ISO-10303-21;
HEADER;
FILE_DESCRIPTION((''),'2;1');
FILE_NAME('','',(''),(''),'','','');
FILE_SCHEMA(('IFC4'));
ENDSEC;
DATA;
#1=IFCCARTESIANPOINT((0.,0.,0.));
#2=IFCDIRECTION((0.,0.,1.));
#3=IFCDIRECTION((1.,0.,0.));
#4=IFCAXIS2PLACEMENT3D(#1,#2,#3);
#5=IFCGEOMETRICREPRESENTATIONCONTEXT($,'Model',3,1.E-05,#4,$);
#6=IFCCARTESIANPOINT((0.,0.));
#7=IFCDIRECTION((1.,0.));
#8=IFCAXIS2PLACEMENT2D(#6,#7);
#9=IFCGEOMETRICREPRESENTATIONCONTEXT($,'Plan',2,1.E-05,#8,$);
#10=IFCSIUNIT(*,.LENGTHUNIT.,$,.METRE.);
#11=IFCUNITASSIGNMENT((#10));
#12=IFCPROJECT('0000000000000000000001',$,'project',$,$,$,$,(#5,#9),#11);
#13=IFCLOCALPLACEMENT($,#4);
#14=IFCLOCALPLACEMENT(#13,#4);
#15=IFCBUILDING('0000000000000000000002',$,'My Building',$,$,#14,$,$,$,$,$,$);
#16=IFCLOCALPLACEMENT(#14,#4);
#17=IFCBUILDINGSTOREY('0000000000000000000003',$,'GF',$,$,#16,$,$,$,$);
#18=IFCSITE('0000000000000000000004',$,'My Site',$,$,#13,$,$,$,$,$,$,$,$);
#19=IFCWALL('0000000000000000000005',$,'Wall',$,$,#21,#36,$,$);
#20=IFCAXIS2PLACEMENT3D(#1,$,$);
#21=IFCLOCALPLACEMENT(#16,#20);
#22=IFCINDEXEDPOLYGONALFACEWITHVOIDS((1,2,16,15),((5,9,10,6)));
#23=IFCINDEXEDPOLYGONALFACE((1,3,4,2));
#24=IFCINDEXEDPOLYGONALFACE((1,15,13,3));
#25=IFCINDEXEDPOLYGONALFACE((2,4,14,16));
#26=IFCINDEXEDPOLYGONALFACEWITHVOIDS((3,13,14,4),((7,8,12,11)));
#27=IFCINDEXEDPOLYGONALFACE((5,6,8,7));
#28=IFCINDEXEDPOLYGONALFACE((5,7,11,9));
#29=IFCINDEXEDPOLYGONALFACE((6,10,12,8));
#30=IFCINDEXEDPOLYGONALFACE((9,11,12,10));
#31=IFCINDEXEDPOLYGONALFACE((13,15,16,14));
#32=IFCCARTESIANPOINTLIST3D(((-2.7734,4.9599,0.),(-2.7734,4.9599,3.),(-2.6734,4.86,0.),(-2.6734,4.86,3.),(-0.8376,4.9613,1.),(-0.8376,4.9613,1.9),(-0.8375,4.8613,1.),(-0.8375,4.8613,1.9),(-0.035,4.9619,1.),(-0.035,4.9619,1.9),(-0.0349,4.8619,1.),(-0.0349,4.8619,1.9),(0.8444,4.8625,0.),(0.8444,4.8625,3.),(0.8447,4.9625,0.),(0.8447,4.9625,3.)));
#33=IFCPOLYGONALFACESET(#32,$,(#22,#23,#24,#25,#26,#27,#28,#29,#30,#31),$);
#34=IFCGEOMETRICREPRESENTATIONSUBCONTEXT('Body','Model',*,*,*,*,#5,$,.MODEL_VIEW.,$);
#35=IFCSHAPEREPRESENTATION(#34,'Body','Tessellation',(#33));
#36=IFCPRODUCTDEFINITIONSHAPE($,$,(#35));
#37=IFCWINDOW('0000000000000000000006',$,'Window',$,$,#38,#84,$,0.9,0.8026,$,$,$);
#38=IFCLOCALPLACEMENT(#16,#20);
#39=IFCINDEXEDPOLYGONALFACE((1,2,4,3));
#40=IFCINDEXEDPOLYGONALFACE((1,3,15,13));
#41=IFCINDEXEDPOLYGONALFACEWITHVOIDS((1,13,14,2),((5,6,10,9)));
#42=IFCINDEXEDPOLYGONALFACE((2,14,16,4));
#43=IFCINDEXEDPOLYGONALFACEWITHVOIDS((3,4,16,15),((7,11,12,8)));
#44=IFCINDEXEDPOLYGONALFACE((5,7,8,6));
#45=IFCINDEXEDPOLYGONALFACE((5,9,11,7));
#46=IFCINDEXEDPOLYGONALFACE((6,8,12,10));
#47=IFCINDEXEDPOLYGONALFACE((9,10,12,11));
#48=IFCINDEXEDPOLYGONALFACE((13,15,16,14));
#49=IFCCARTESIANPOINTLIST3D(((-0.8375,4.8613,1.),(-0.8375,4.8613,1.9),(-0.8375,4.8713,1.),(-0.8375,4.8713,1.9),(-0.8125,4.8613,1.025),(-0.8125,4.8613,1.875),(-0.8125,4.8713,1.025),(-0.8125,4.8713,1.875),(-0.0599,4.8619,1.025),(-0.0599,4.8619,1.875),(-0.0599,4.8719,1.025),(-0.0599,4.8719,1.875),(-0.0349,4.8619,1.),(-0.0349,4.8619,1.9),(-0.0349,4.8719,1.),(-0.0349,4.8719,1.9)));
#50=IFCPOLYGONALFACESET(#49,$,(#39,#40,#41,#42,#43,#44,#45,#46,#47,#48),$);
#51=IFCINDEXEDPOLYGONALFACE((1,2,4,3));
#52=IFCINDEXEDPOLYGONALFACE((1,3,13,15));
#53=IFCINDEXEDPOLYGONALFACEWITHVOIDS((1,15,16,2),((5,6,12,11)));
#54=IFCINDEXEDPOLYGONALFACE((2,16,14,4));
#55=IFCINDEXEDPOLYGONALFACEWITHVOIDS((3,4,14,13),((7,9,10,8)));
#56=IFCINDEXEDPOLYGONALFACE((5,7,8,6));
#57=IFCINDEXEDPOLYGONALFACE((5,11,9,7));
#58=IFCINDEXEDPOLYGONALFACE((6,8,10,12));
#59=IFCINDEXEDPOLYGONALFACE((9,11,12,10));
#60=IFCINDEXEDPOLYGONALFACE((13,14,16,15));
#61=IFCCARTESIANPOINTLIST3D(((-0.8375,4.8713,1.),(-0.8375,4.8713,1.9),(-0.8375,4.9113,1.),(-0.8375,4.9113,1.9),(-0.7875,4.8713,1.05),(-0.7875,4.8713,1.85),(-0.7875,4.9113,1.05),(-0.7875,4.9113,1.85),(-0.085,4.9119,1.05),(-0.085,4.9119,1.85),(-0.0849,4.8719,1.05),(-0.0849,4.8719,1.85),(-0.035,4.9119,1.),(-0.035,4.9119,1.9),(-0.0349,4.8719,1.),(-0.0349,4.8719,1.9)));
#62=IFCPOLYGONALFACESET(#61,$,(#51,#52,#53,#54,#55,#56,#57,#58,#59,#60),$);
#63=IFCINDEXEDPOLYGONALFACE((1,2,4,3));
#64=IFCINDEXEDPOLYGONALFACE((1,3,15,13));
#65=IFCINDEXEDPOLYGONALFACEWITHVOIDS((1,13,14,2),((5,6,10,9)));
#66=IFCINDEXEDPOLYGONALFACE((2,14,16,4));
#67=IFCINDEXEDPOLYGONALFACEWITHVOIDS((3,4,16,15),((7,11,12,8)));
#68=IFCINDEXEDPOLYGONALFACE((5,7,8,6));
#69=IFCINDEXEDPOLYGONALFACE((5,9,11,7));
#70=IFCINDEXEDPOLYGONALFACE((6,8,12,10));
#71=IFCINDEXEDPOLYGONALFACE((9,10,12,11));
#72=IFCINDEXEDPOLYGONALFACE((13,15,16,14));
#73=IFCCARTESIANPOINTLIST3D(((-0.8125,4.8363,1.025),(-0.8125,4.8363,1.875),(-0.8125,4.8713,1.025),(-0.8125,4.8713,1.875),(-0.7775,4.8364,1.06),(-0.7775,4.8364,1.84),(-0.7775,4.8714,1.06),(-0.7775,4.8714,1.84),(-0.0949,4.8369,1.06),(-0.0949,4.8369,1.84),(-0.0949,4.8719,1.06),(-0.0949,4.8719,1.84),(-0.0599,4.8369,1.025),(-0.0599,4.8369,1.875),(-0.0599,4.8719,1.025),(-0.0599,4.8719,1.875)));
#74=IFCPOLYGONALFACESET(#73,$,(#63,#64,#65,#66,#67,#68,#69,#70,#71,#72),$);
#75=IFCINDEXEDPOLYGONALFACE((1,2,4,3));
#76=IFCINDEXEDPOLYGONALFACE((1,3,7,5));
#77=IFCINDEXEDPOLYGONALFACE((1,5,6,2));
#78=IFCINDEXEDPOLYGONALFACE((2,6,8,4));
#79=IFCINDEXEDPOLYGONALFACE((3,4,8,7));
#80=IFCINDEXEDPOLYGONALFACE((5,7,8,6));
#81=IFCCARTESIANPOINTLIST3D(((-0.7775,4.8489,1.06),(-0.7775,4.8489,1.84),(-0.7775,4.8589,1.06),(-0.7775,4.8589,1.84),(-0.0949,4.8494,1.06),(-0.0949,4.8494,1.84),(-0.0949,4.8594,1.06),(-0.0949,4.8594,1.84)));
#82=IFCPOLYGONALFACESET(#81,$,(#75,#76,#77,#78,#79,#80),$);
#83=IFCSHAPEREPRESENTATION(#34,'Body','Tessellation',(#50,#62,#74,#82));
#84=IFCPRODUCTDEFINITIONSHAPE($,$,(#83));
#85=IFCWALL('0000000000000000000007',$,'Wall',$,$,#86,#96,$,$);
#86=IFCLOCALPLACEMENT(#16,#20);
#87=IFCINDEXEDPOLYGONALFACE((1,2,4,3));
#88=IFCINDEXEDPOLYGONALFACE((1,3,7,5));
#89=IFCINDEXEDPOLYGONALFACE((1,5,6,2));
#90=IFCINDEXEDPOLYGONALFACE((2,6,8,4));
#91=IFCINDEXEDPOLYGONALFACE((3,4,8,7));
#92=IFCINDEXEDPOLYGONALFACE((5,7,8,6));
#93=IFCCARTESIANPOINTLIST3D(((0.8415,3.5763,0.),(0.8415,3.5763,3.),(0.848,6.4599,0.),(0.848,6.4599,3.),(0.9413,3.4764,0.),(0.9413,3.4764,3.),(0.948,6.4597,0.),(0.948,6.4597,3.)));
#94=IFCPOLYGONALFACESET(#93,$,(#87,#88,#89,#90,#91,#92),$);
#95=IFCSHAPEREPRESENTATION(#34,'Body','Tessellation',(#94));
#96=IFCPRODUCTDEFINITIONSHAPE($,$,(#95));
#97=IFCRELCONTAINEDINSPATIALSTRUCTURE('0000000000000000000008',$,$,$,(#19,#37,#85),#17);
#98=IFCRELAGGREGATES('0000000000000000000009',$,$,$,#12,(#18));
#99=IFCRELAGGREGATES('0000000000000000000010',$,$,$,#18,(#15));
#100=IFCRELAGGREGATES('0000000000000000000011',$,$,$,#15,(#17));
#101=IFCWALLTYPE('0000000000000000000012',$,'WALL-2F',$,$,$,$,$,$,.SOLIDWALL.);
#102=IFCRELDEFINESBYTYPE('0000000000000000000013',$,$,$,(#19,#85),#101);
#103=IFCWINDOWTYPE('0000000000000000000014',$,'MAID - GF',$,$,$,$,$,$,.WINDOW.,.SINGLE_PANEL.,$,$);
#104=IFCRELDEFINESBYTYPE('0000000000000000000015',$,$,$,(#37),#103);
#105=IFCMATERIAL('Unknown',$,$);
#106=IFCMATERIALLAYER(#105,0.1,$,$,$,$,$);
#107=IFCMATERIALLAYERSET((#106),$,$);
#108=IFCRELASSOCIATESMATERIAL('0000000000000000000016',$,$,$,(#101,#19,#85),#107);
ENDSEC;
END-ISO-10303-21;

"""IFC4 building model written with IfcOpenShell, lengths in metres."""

from ifc_helpers import new_model, entity, si_unit, frame, origin_with_axes, origin_2d_with_axis, place, context, subcontext, project, spatial, line, indexed_curve, outline, extrude, shape, source, transform, mapped, material, layer, layer_set, layer_usage, type_object, type_shapes, element, fill, save


model = new_model("IFC4")

# Units and contexts
model_context = context("Model", 3, precision=1e-05, world=origin_with_axes())
plan_context = context("Plan", 2, precision=1e-05, world=origin_2d_with_axis())
body_context_1 = subcontext(model_context, "Body", "Model", "MODEL_VIEW")
body_context_2 = subcontext(plan_context, "Body", "Plan", "PLAN_VIEW")
ifc_project = project(units=[si_unit("LENGTHUNIT", "METRE")], contexts=[model_context, plan_context])

# Site, building, storey
site_placement = place(None, origin_with_axes())
site = spatial("IfcSite", under=ifc_project, at=site_placement, Name="My Site")
building_placement = place(site_placement, origin_with_axes())
building = spatial("IfcBuilding", under=site, at=building_placement, Name="My Building")
storey_placement = place(building_placement, origin_with_axes())
storey = spatial("IfcBuildingStorey", under=building, at=storey_placement, Name="GF")

# Shared definitions
ifc_material_1 = material(Name="Unknown")

# Shared definitions
ifc_layer_1 = layer(ifc_material_1, 0.1)
ifc_layer_set_1 = layer_set([ifc_layer_1])
wall_type_1 = type_object("IfcWallType", Name="WALL-2F", PredefinedType="SOLIDWALL", material=ifc_layer_set_1)

# Wall, opening, window
ifc_layer_usage_1 = layer_usage(ifc_layer_set_1, "AXIS2", "POSITIVE", 0.0)
wall_1_placement = place(storey_placement, frame((-2.7734, 4.8599, 0.0), z_axis=(0.0, 0.0, 1.0), x_axis=(1.0, 0.000731, 0.0)))
wall_1 = element("IfcWall", 1, at=wall_1_placement, inside=storey, type_object=wall_type_1, material=ifc_layer_usage_1, Name="Wall", context=body_context_1, shape_type="SweptSolid", body=[
    extrude(outline(indexed_curve([(0.1, 0.0), (0.0001, 0.1), (3.6181, 0.1), (3.6178, 0.0)], segments=[line(1, 2, 3, 4, 1)])), origin_with_axes(), (0.0, 0.0, 1.0), 3.0),
])
shared_shape_1 = source(origin_with_axes(), body_context_1, "Body", "SweptSolid", [
    extrude(outline(indexed_curve([(0.0, 0.0), (0.8026, 0.0), (0.8026, 0.9), (0.0, 0.9)], segments=[line(1, 2, 3, 4, 1)])), frame((0.0, -0.6, 0.0), z_axis=(0.0, -1.0, 0.0), x_axis=(1.0, 0.0, 0.0)), (0.0, 0.0, -1.0), 1.2),
])
opening_1_placement = place(wall_1_placement, frame((2.7385, 0.1, 1.0), z_axis=(0.0, 0.0, 1.0), x_axis=(-1.0, 0.0, 0.0)))
opening_1 = element("IfcOpeningElement", 2, at=opening_1_placement, cuts=wall_1, PredefinedType="OPENING", context=body_context_1, shape_type="MappedRepresentation", body=[
    mapped(shared_shape_1, transform((0.0, 0.0, 0.0), x_axis=(1.0, 0.0, 0.0), y_axis=(0.0, 1.0, 0.0), z_axis=(0.0, 0.0, 1.0), scale=1.0)),
])
window_type_1 = type_object("IfcWindowType", Name="MAID - GF", PartitioningType="SINGLE_PANEL", PredefinedType="WINDOW")
shared_shape_2 = source(origin_with_axes(), body_context_1, "Body", "SweptSolid", [
    extrude(outline(indexed_curve([(0.0, 0.0), (0.8026, 0.0), (0.8026, 0.9), (0.0, 0.9)], segments=[line(1, 2, 3, 4, 1)]), holes=[indexed_curve([(0.025, 0.025), (0.7776, 0.025), (0.7776, 0.875), (0.025, 0.875)], segments=[line(1, 2, 3, 4, 1)])]), frame((0.0, 0.09, 0.0), z_axis=(0.0, -1.0, 0.0), x_axis=(1.0, 0.0, 0.0)), (0.0, 0.0, -1.0), 0.01),
    extrude(outline(indexed_curve([(0.0, 0.0), (0.8026, 0.0), (0.8026, 0.9), (0.0, 0.9)], segments=[line(1, 2, 3, 4, 1)]), holes=[indexed_curve([(0.05, 0.05), (0.7526, 0.05), (0.7526, 0.85), (0.05, 0.85)], segments=[line(1, 2, 3, 4, 1)])]), frame((0.0, 0.05, 0.0), z_axis=(0.0, -1.0, 0.0), x_axis=(1.0, 0.0, 0.0)), (0.0, 0.0, -1.0), 0.04),
    extrude(outline(indexed_curve([(0.0, 0.0), (0.7526, 0.0), (0.7526, 0.85), (0.0, 0.85)], segments=[line(1, 2, 3, 4, 1)]), holes=[indexed_curve([(0.035, 0.035), (0.7176, 0.035), (0.7176, 0.815), (0.035, 0.815)], segments=[line(1, 2, 3, 4, 1)])]), frame((0.025, 0.09, 0.025), z_axis=(0.0, -1.0, 0.0), x_axis=(1.0, 0.0, 0.0)), (0.0, 0.0, -1.0), 0.035),
    extrude(outline(indexed_curve([(0.035, 0.035), (0.7176, 0.035), (0.7176, 0.815), (0.035, 0.815)], segments=[line(1, 2, 3, 4, 1)])), frame((0.025, 0.1025, 0.025), z_axis=(0.0, -1.0, 0.0), x_axis=(1.0, 0.0, 0.0)), (0.0, 0.0, -1.0), 0.01),
])
shared_shape_3 = source(origin_with_axes(), body_context_2, "Body", "Curve2D", [
    entity("IfcIndexedPolyCurve", entity("IfcCartesianPointList2D", [[0.05, 0.05], [0.7526, 0.05]])),
    entity("IfcIndexedPolyCurve", entity("IfcCartesianPointList2D", [[0.0, 0.1], [0.025, 0.1], [0.025, 0.09], [0.05, 0.09], [0.05, 0.05], [0.0, 0.05]]), [entity("IfcLineIndex", [1, 2, 3, 4, 5, 6, 1])]),
    entity("IfcIndexedPolyCurve", entity("IfcCartesianPointList2D", [[0.8026, 0.1], [0.7776, 0.1], [0.7776, 0.09], [0.7526, 0.09], [0.7526, 0.05], [0.8026, 0.05]]), [entity("IfcLineIndex", [1, 2, 3, 4, 5, 6, 1])]),
    entity("IfcIndexedPolyCurve", entity("IfcCartesianPointList2D", [[0.025, 0.09], [0.06, 0.09], [0.06, 0.125], [0.025, 0.125]]), [entity("IfcLineIndex", [1, 2, 3, 4, 1])]),
    entity("IfcIndexedPolyCurve", entity("IfcCartesianPointList2D", [[0.7776, 0.09], [0.7426, 0.09], [0.7426, 0.125], [0.7776, 0.125]]), [entity("IfcLineIndex", [1, 2, 3, 4, 1])]),
    entity("IfcIndexedPolyCurve", entity("IfcCartesianPointList2D", [[0.06, 0.09], [0.7426, 0.09]])),
    entity("IfcIndexedPolyCurve", entity("IfcCartesianPointList2D", [[0.06, 0.125], [0.7426, 0.125]])),
    entity("IfcIndexedPolyCurve", entity("IfcCartesianPointList2D", [[0.06, 0.1075], [0.7426, 0.1075]])),
])
type_shapes(window_type_1, [shared_shape_2, shared_shape_3])
window_1_placement = place(opening_1_placement, frame((0.0, 0.0, 0.0), z_axis=(0.0, 0.0, 1.0), x_axis=(1.0, 0.0, 0.0)))
window_1 = element("IfcWindow", 3, at=window_1_placement, inside=storey, type_object=window_type_1, Name="Window", OverallHeight=0.9, OverallWidth=0.8026, shapes=[
    shape(body_context_1, "Body", "MappedRepresentation", [mapped(shared_shape_2, transform((0.0, 0.0, 0.0), x_axis=(1.0, 0.0, 0.0), y_axis=(0.0, 1.0, 0.0), z_axis=(0.0, 0.0, 1.0), scale=1.0))]),
    shape(body_context_2, "Body", "MappedRepresentation", [mapped(shared_shape_3, transform((0.0, 0.0, 0.0), x_axis=(1.0, 0.0, 0.0), y_axis=(0.0, 1.0, 0.0), z_axis=(0.0, 0.0, 1.0), scale=1.0))]),
])
fill(opening_1, window_1)

# Wall
ifc_layer_usage_2 = layer_usage(ifc_layer_set_1, "AXIS2", "POSITIVE", 0.0)
wall_2_placement = place(storey_placement, frame((0.848, 6.4599, 0.0), z_axis=(0.0, 0.0, 1.0), x_axis=(-0.00226, -0.999997, 0.0)))
element("IfcWall", 4, at=wall_2_placement, inside=storey, type_object=wall_type_1, material=ifc_layer_usage_2, Name="Wall", context=body_context_1, shape_type="SweptSolid", body=[
    extrude(outline(indexed_curve([(0.0, 0.0), (0.0, 0.1), (2.9833, 0.1), (2.8836, 0.0)], segments=[line(1, 2, 3, 4, 1)])), origin_with_axes(), (0.0, 0.0, 1.0), 3.0),
])

save(model, "model.ifc")
